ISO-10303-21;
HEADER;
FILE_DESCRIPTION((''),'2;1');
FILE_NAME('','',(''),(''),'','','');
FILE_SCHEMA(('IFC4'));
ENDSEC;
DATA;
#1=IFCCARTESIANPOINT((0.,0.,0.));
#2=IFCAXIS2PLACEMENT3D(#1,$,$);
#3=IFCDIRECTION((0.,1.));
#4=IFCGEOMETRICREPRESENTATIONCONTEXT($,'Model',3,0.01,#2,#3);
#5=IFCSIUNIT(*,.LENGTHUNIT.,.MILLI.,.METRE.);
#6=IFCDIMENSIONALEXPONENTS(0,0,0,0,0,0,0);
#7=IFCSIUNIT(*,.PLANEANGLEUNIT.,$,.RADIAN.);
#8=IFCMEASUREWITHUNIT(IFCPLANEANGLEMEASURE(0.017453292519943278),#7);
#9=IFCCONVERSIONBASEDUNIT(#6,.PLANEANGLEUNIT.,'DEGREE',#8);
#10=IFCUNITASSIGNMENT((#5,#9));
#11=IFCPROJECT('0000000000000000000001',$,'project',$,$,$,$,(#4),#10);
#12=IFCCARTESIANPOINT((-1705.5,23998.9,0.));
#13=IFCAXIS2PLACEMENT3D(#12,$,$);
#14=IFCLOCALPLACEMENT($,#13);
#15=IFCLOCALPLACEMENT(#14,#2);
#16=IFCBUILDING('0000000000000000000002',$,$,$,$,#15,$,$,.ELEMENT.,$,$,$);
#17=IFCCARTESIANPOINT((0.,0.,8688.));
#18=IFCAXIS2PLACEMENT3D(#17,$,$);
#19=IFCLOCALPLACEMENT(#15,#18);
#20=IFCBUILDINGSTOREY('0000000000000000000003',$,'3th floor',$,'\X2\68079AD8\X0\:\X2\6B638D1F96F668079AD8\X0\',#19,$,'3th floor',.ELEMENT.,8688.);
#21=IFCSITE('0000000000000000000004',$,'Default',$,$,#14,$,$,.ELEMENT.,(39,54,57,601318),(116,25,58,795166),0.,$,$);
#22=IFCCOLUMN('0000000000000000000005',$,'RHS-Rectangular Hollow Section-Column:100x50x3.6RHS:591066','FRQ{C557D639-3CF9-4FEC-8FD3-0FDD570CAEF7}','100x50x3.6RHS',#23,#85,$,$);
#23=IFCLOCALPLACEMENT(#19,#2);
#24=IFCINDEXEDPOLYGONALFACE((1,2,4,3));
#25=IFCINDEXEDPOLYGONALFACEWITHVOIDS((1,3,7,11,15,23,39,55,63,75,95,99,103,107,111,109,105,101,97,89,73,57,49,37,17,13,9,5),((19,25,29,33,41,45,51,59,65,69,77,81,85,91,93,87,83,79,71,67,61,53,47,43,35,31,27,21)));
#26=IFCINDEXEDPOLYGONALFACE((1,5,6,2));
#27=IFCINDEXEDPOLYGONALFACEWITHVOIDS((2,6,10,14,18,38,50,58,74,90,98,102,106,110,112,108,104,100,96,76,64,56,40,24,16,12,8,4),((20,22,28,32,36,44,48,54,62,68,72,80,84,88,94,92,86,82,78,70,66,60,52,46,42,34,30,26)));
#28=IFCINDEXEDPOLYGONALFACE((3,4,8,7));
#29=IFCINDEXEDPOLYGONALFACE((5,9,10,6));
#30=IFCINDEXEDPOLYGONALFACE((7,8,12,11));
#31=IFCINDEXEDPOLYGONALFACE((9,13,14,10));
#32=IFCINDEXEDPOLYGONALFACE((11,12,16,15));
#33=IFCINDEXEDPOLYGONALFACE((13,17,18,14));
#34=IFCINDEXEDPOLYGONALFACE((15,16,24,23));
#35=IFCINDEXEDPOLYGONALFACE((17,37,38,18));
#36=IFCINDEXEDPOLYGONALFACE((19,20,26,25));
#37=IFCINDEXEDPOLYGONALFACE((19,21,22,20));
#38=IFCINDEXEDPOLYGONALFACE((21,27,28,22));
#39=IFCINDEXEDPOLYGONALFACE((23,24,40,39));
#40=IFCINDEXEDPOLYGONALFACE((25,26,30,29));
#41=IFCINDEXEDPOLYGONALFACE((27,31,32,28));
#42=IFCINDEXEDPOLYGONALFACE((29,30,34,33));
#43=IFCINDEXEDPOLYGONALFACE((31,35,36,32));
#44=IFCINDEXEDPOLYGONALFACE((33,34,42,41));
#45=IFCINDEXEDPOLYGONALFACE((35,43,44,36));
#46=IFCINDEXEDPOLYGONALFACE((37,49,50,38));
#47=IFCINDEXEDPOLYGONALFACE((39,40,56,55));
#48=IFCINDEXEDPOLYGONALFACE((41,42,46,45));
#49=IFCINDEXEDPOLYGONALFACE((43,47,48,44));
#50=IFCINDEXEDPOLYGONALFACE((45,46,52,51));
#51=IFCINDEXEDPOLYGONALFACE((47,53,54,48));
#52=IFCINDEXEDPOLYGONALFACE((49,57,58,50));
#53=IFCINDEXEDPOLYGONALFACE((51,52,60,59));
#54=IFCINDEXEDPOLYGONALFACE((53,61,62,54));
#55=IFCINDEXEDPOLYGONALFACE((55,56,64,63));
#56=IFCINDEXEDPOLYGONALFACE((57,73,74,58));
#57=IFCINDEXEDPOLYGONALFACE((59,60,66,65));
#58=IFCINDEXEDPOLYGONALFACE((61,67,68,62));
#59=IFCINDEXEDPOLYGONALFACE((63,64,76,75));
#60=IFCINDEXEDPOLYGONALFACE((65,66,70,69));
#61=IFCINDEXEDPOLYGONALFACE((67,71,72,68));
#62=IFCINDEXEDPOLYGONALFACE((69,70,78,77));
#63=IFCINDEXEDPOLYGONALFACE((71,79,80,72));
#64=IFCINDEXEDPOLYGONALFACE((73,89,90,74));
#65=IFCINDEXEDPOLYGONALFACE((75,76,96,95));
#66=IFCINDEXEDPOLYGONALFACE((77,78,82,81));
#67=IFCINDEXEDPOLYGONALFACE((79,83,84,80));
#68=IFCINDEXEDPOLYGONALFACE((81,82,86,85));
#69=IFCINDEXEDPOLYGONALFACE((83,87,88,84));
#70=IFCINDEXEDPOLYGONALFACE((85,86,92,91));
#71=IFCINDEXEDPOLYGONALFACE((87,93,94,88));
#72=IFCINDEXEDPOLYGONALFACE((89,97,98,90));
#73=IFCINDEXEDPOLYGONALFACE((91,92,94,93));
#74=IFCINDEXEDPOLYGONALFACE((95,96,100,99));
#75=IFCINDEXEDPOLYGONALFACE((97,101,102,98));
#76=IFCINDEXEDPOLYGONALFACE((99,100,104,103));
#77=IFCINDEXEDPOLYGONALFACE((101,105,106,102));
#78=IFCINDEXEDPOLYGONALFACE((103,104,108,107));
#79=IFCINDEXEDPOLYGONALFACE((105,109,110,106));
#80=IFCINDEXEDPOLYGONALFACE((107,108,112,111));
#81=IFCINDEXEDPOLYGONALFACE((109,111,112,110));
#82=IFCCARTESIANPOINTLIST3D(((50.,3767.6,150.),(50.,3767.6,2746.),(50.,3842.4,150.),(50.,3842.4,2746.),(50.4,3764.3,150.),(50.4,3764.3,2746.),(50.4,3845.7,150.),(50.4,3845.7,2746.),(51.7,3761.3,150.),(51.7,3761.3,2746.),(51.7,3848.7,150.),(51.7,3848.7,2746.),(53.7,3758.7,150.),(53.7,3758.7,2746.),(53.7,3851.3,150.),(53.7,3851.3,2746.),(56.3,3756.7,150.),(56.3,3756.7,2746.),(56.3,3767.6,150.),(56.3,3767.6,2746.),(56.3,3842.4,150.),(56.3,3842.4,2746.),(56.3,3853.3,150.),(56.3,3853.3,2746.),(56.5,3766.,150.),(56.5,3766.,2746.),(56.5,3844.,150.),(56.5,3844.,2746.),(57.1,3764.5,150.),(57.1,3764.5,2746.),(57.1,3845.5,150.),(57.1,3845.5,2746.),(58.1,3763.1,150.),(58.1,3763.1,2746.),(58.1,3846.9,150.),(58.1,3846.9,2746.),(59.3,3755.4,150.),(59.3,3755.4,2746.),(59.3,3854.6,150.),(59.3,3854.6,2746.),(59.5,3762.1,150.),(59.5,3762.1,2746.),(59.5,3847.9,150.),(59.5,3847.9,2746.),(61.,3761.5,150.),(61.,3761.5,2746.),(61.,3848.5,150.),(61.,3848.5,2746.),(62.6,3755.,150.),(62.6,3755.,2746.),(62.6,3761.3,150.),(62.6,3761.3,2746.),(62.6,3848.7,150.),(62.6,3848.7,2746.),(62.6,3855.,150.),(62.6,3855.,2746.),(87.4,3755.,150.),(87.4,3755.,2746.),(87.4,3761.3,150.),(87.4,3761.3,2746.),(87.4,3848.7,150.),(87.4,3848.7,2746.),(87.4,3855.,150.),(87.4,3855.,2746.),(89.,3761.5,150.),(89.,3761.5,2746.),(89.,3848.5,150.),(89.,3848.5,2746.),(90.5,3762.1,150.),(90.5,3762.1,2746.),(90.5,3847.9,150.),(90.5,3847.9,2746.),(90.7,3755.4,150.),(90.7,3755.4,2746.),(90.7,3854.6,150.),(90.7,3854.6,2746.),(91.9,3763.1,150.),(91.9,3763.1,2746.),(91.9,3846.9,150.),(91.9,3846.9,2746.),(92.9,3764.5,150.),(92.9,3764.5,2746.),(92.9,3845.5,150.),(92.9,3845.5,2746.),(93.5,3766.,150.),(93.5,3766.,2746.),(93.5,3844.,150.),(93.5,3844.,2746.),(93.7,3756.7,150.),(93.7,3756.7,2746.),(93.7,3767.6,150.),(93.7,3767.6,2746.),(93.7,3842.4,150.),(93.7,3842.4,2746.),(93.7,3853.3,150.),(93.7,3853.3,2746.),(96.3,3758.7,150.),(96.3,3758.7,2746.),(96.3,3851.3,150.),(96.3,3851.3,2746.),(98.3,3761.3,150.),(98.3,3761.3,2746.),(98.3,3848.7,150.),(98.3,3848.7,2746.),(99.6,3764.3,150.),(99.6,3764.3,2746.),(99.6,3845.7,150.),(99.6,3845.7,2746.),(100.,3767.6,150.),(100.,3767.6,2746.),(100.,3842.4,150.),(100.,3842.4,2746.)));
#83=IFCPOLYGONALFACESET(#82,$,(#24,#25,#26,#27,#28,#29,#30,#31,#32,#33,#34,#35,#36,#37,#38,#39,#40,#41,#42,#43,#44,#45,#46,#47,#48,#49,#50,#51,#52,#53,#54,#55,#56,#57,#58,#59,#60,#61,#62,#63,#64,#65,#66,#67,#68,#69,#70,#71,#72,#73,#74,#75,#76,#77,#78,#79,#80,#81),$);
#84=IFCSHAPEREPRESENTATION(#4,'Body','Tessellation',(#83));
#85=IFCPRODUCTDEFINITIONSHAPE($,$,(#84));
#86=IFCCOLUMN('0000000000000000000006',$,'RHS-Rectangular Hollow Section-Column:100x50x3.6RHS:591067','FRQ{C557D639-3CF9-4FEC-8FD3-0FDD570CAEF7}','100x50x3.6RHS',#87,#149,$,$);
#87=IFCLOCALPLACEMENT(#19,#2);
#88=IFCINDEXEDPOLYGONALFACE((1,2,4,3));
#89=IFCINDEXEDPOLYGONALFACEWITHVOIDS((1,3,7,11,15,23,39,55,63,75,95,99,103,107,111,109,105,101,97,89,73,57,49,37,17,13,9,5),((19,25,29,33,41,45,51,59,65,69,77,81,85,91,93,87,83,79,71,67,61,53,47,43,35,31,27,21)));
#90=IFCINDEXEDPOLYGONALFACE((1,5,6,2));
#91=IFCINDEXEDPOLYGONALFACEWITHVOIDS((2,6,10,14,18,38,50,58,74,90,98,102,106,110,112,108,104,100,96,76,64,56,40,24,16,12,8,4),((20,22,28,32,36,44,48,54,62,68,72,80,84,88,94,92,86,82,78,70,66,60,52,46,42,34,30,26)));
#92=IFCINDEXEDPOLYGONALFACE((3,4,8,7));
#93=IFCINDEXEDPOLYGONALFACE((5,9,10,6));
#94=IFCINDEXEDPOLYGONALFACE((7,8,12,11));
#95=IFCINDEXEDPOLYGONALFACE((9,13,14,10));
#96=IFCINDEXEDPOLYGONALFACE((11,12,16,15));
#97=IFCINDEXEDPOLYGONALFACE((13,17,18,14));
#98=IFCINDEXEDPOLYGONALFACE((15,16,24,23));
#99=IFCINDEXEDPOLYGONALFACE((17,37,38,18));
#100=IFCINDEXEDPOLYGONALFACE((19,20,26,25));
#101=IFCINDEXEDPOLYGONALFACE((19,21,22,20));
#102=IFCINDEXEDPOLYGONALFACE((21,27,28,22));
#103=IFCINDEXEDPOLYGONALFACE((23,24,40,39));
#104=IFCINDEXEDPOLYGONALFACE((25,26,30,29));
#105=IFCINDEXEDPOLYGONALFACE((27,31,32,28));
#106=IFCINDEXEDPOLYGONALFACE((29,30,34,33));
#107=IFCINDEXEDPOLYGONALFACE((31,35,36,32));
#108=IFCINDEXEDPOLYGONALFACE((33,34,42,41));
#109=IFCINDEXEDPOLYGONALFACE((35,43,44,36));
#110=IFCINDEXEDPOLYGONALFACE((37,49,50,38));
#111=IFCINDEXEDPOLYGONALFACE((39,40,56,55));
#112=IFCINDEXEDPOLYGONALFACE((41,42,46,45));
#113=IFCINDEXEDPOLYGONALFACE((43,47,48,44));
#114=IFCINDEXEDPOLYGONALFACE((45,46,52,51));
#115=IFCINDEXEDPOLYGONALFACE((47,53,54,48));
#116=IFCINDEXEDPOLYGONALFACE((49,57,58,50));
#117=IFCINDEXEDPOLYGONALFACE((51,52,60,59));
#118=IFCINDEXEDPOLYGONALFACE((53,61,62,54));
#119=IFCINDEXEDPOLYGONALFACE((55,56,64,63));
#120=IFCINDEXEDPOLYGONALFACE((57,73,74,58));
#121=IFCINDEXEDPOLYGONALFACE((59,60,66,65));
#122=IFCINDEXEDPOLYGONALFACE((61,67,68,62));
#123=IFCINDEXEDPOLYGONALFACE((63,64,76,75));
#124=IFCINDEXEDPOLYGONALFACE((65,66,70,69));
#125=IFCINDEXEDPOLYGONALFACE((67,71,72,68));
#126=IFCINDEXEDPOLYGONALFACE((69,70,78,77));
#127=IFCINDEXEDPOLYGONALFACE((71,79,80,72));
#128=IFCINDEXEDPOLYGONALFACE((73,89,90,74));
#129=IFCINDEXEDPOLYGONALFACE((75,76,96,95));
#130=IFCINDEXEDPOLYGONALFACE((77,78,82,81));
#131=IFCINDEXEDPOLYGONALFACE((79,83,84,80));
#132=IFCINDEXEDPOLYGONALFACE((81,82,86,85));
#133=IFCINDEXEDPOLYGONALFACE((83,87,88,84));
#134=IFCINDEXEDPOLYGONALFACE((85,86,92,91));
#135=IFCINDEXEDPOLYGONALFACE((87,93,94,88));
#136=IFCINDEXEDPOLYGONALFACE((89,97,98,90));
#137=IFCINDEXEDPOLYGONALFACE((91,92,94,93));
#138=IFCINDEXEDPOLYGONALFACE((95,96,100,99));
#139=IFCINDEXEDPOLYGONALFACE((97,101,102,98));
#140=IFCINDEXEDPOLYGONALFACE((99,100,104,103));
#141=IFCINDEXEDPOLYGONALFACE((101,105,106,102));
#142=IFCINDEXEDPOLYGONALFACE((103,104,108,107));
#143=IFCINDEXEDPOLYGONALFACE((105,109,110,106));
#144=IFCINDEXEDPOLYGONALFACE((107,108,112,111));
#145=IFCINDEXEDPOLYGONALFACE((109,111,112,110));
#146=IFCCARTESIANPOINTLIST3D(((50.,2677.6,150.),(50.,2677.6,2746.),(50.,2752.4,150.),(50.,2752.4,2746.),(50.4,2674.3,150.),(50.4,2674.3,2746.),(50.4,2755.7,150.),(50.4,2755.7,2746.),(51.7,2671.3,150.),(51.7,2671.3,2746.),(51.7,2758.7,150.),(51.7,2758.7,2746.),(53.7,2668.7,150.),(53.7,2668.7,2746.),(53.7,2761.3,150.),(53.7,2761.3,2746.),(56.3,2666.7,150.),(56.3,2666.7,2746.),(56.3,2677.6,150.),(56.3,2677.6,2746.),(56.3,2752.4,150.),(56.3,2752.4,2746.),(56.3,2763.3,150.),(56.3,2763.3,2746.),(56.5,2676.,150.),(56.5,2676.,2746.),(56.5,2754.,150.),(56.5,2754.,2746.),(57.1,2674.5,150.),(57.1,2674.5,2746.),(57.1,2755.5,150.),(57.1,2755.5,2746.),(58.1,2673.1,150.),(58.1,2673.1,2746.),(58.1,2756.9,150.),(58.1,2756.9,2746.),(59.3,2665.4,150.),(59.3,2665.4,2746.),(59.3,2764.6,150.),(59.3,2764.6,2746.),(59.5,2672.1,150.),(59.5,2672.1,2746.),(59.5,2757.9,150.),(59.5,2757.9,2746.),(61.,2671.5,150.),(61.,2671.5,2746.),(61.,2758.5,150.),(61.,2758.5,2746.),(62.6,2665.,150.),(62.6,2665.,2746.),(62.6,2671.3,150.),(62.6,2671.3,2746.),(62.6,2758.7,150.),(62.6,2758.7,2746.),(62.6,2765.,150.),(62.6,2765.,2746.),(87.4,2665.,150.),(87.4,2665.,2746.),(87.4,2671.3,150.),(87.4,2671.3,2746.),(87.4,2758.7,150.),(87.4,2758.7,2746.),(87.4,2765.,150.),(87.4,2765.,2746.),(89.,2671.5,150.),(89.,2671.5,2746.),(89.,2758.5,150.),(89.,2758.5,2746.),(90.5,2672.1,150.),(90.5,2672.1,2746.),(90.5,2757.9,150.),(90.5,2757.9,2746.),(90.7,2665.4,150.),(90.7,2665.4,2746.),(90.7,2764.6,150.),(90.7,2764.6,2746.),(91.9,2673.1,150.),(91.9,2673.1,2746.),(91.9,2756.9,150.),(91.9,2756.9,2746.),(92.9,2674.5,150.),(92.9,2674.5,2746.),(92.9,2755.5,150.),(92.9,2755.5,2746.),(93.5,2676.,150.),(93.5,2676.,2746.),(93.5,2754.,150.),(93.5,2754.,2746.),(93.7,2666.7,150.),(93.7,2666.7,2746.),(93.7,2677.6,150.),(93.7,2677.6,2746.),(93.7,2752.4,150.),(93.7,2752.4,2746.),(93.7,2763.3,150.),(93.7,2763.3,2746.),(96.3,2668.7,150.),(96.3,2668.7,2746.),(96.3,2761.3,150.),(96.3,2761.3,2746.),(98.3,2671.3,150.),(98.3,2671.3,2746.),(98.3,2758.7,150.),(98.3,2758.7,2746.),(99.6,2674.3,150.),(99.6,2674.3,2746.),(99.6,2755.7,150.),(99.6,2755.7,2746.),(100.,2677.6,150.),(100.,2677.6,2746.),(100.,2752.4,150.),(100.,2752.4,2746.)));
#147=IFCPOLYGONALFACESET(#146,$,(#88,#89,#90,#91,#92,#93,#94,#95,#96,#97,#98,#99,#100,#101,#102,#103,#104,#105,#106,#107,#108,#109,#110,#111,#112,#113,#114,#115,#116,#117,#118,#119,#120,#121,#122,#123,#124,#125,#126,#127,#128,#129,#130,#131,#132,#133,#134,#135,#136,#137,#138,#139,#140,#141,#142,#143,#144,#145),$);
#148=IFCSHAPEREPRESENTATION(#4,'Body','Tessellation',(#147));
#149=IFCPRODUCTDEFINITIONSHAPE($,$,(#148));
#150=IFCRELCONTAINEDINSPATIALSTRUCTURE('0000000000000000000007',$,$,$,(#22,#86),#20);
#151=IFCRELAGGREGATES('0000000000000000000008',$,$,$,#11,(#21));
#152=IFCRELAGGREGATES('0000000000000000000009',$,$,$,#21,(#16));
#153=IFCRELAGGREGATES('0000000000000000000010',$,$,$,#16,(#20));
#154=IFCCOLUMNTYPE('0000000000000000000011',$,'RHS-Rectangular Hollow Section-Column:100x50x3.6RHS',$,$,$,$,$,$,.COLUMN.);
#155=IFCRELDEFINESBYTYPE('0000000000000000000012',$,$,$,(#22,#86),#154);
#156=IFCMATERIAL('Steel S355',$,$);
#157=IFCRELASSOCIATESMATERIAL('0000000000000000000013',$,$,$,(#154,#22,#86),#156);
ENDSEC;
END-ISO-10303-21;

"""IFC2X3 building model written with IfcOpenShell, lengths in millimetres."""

from ifc_helpers import new_model, entity, si_unit, converted_unit, point, direction, frame, frame_2d, origin, origin_2d, place, context, project, spatial, circle_curve, line_curve, trimmed, segment, composite_curve, hollow_rectangle, outline, extrude, clip, halfspace, material, type_object, element, save


model = new_model("IFC2X3")

# Units and contexts
model_context = context("Model", 3, precision=0.01, world=origin(), true_north=direction((0.0, 1.0)))
ifc_project = project(units=[si_unit("LENGTHUNIT", "METRE", prefix="MILLI"), converted_unit("PLANEANGLEUNIT", "DEGREE", entity("IfcPlaneAngleMeasure", 0.017453292519943278), si_unit("PLANEANGLEUNIT", "RADIAN"), dimensions=[0, 0, 0, 0, 0, 0, 0])], contexts=[model_context])

# Site, building, storey
site_placement = place(None, frame((-1705.5, 23998.9, 0.0)))
site = spatial("IfcSite", under=ifc_project, at=site_placement, Name="Default", CompositionType="ELEMENT", RefLatitude=(39, 54, 57, 601318), RefLongitude=(116, 25, 58, 795166), RefElevation=0.0)
building_placement = place(site_placement, origin())
building = spatial("IfcBuilding", under=site, at=building_placement, CompositionType="ELEMENT")
storey_placement = place(building_placement, frame((0.0, 0.0, 8688.0)))
storey = spatial("IfcBuildingStorey", under=building, at=storey_placement, Name="3th floor", ObjectType="标高:正负零标高", LongName="3th floor", CompositionType="ELEMENT", Elevation=8688.0)

# Shared definitions
ifc_material_1 = material(Name="Steel S355")

# Columns, openings
column_type_1 = type_object("IfcColumnType", Name="RHS-Rectangular Hollow Section-Column:100x50x3.6RHS", PredefinedType="COLUMN", material=ifc_material_1)
column_1_placement = place(storey_placement, frame((75.0, 3805.0, 2876.9)))
column_1 = element("IfcColumn", 1, at=column_1_placement, inside=storey, type_object=column_type_1, material=ifc_material_1, Name="RHS-Rectangular Hollow Section-Column:100x50x3.6RHS:591066", Description="FRQ{C557D639-3CF9-4FEC-8FD3-0FDD570CAEF7}", ObjectType="100x50x3.6RHS", context=model_context, shape_type="Clipping", body=[
    clip(clip(extrude(hollow_rectangle(XDim=50.0, YDim=100.0, WallThickness=6.3, InnerFilletRadius=6.3, OuterFilletRadius=12.6, at=origin_2d()), origin(), (0.0, 0.0, -1.0), 2782.8), halfspace(frame((-75.0, -3805.0, -55.9), z_axis=(0.0, 0.0, -1.0), x_axis=(-1.0, 0.0, 0.0)), True)), halfspace(frame((-75.0, -3805.0, -2726.9), z_axis=(0.0, 0.0, 1.0), x_axis=(1.0, 0.0, 0.0)), True)),
])
opening_1_placement = place(column_1_placement, frame((0.0, -150.1, -130.9), z_axis=(0.0, 1.0, 0.0), x_axis=(-1.0, 0.0, 0.0)))
element("IfcOpeningElement", 2, at=opening_1_placement, cuts=column_1, ObjectType="Opening", context=model_context, shape_type="SweptSolid", body=[
    extrude(outline(composite_curve([segment(trimmed(circle_curve(frame_2d((43.0, 32.0), x_axis=(1.0, 0.0)), 32.0), [point((43.0, 0.0))], [point((75.0, 32.0))], True, "CARTESIAN"), True, "CONTINUOUS"), segment(trimmed(line_curve((75.0, 32.0), (0.0, 1.0), 86.0), [point((75.0, 32.0))], [point((75.0, 118.0))], True, "CARTESIAN"), True, "CONTINUOUS"), segment(trimmed(circle_curve(frame_2d((43.0, 118.0), x_axis=(1.0, 0.0)), 32.0), [point((75.0, 118.0))], [point((43.0, 150.0))], True, "CARTESIAN"), True, "CONTINUOUS"), segment(trimmed(line_curve((43.0, 150.0), (-1.0, 0.0), 86.0), [point((43.0, 150.0))], [point((-43.0, 150.0))], True, "CARTESIAN"), True, "CONTINUOUS"), segment(trimmed(circle_curve(frame_2d((-43.0, 118.0), x_axis=(1.0, 0.0)), 32.0), [point((-43.0, 150.0))], [point((-75.0, 118.0))], True, "CARTESIAN"), True, "CONTINUOUS"), segment(trimmed(line_curve((-75.0, 118.0), (0.0, -1.0), 86.0), [point((-75.0, 118.0))], [point((-75.0, 32.0))], True, "CARTESIAN"), True, "CONTINUOUS"), segment(trimmed(circle_curve(frame_2d((-43.0, 32.0), x_axis=(1.0, 0.0)), 32.0), [point((-75.0, 32.0))], [point((-43.0, 0.0))], True, "CARTESIAN"), True, "CONTINUOUS"), segment(trimmed(line_curve((-43.0, 0.0), (1.0, 0.0), 86.0), [point((-43.0, 0.0))], [point((43.0, 0.0))], True, "CARTESIAN"), True, "CONTINUOUS")], self_intersect="UNKNOWN")), origin(), (0.0, 0.0, 1.0), 300.2),
])
column_2_placement = place(storey_placement, frame((75.0, 2715.0, 2876.9)))
column_2 = element("IfcColumn", 3, at=column_2_placement, inside=storey, type_object=column_type_1, material=ifc_material_1, Name="RHS-Rectangular Hollow Section-Column:100x50x3.6RHS:591067", Description="FRQ{C557D639-3CF9-4FEC-8FD3-0FDD570CAEF7}", ObjectType="100x50x3.6RHS", context=model_context, shape_type="Clipping", body=[
    clip(clip(extrude(hollow_rectangle(XDim=50.0, YDim=100.0, WallThickness=6.3, InnerFilletRadius=6.3, OuterFilletRadius=12.6, at=origin_2d()), origin(), (0.0, 0.0, -1.0), 2782.8), halfspace(frame((-75.0, -2715.0, -55.9), z_axis=(0.0, 0.0, -1.0), x_axis=(-1.0, 0.0, 0.0)), True)), halfspace(frame((-75.0, -2715.0, -2726.9), z_axis=(0.0, 0.0, 1.0), x_axis=(1.0, 0.0, 0.0)), True)),
])
opening_2_placement = place(column_2_placement, frame((0.0, -150.1, -130.9), z_axis=(0.0, 1.0, 0.0), x_axis=(-1.0, 0.0, 0.0)))
element("IfcOpeningElement", 4, at=opening_2_placement, cuts=column_2, ObjectType="Opening", context=model_context, shape_type="SweptSolid", body=[
    extrude(outline(composite_curve([segment(trimmed(circle_curve(frame_2d((43.0, 32.0), x_axis=(1.0, 0.0)), 32.0), [point((43.0, 0.0))], [point((75.0, 32.0))], True, "CARTESIAN"), True, "CONTINUOUS"), segment(trimmed(line_curve((75.0, 32.0), (0.0, 1.0), 86.0), [point((75.0, 32.0))], [point((75.0, 118.0))], True, "CARTESIAN"), True, "CONTINUOUS"), segment(trimmed(circle_curve(frame_2d((43.0, 118.0), x_axis=(1.0, 0.0)), 32.0), [point((75.0, 118.0))], [point((43.0, 150.0))], True, "CARTESIAN"), True, "CONTINUOUS"), segment(trimmed(line_curve((43.0, 150.0), (-1.0, 0.0), 86.0), [point((43.0, 150.0))], [point((-43.0, 150.0))], True, "CARTESIAN"), True, "CONTINUOUS"), segment(trimmed(circle_curve(frame_2d((-43.0, 118.0), x_axis=(1.0, 0.0)), 32.0), [point((-43.0, 150.0))], [point((-75.0, 118.0))], True, "CARTESIAN"), True, "CONTINUOUS"), segment(trimmed(line_curve((-75.0, 118.0), (0.0, -1.0), 86.0), [point((-75.0, 118.0))], [point((-75.0, 32.0))], True, "CARTESIAN"), True, "CONTINUOUS"), segment(trimmed(circle_curve(frame_2d((-43.0, 32.0), x_axis=(1.0, 0.0)), 32.0), [point((-75.0, 32.0))], [point((-43.0, 0.0))], True, "CARTESIAN"), True, "CONTINUOUS"), segment(trimmed(line_curve((-43.0, 0.0), (1.0, 0.0), 86.0), [point((-43.0, 0.0))], [point((43.0, 0.0))], True, "CARTESIAN"), True, "CONTINUOUS")], self_intersect="UNKNOWN")), origin(), (0.0, 0.0, 1.0), 300.2),
])

save(model, "model.ifc")
